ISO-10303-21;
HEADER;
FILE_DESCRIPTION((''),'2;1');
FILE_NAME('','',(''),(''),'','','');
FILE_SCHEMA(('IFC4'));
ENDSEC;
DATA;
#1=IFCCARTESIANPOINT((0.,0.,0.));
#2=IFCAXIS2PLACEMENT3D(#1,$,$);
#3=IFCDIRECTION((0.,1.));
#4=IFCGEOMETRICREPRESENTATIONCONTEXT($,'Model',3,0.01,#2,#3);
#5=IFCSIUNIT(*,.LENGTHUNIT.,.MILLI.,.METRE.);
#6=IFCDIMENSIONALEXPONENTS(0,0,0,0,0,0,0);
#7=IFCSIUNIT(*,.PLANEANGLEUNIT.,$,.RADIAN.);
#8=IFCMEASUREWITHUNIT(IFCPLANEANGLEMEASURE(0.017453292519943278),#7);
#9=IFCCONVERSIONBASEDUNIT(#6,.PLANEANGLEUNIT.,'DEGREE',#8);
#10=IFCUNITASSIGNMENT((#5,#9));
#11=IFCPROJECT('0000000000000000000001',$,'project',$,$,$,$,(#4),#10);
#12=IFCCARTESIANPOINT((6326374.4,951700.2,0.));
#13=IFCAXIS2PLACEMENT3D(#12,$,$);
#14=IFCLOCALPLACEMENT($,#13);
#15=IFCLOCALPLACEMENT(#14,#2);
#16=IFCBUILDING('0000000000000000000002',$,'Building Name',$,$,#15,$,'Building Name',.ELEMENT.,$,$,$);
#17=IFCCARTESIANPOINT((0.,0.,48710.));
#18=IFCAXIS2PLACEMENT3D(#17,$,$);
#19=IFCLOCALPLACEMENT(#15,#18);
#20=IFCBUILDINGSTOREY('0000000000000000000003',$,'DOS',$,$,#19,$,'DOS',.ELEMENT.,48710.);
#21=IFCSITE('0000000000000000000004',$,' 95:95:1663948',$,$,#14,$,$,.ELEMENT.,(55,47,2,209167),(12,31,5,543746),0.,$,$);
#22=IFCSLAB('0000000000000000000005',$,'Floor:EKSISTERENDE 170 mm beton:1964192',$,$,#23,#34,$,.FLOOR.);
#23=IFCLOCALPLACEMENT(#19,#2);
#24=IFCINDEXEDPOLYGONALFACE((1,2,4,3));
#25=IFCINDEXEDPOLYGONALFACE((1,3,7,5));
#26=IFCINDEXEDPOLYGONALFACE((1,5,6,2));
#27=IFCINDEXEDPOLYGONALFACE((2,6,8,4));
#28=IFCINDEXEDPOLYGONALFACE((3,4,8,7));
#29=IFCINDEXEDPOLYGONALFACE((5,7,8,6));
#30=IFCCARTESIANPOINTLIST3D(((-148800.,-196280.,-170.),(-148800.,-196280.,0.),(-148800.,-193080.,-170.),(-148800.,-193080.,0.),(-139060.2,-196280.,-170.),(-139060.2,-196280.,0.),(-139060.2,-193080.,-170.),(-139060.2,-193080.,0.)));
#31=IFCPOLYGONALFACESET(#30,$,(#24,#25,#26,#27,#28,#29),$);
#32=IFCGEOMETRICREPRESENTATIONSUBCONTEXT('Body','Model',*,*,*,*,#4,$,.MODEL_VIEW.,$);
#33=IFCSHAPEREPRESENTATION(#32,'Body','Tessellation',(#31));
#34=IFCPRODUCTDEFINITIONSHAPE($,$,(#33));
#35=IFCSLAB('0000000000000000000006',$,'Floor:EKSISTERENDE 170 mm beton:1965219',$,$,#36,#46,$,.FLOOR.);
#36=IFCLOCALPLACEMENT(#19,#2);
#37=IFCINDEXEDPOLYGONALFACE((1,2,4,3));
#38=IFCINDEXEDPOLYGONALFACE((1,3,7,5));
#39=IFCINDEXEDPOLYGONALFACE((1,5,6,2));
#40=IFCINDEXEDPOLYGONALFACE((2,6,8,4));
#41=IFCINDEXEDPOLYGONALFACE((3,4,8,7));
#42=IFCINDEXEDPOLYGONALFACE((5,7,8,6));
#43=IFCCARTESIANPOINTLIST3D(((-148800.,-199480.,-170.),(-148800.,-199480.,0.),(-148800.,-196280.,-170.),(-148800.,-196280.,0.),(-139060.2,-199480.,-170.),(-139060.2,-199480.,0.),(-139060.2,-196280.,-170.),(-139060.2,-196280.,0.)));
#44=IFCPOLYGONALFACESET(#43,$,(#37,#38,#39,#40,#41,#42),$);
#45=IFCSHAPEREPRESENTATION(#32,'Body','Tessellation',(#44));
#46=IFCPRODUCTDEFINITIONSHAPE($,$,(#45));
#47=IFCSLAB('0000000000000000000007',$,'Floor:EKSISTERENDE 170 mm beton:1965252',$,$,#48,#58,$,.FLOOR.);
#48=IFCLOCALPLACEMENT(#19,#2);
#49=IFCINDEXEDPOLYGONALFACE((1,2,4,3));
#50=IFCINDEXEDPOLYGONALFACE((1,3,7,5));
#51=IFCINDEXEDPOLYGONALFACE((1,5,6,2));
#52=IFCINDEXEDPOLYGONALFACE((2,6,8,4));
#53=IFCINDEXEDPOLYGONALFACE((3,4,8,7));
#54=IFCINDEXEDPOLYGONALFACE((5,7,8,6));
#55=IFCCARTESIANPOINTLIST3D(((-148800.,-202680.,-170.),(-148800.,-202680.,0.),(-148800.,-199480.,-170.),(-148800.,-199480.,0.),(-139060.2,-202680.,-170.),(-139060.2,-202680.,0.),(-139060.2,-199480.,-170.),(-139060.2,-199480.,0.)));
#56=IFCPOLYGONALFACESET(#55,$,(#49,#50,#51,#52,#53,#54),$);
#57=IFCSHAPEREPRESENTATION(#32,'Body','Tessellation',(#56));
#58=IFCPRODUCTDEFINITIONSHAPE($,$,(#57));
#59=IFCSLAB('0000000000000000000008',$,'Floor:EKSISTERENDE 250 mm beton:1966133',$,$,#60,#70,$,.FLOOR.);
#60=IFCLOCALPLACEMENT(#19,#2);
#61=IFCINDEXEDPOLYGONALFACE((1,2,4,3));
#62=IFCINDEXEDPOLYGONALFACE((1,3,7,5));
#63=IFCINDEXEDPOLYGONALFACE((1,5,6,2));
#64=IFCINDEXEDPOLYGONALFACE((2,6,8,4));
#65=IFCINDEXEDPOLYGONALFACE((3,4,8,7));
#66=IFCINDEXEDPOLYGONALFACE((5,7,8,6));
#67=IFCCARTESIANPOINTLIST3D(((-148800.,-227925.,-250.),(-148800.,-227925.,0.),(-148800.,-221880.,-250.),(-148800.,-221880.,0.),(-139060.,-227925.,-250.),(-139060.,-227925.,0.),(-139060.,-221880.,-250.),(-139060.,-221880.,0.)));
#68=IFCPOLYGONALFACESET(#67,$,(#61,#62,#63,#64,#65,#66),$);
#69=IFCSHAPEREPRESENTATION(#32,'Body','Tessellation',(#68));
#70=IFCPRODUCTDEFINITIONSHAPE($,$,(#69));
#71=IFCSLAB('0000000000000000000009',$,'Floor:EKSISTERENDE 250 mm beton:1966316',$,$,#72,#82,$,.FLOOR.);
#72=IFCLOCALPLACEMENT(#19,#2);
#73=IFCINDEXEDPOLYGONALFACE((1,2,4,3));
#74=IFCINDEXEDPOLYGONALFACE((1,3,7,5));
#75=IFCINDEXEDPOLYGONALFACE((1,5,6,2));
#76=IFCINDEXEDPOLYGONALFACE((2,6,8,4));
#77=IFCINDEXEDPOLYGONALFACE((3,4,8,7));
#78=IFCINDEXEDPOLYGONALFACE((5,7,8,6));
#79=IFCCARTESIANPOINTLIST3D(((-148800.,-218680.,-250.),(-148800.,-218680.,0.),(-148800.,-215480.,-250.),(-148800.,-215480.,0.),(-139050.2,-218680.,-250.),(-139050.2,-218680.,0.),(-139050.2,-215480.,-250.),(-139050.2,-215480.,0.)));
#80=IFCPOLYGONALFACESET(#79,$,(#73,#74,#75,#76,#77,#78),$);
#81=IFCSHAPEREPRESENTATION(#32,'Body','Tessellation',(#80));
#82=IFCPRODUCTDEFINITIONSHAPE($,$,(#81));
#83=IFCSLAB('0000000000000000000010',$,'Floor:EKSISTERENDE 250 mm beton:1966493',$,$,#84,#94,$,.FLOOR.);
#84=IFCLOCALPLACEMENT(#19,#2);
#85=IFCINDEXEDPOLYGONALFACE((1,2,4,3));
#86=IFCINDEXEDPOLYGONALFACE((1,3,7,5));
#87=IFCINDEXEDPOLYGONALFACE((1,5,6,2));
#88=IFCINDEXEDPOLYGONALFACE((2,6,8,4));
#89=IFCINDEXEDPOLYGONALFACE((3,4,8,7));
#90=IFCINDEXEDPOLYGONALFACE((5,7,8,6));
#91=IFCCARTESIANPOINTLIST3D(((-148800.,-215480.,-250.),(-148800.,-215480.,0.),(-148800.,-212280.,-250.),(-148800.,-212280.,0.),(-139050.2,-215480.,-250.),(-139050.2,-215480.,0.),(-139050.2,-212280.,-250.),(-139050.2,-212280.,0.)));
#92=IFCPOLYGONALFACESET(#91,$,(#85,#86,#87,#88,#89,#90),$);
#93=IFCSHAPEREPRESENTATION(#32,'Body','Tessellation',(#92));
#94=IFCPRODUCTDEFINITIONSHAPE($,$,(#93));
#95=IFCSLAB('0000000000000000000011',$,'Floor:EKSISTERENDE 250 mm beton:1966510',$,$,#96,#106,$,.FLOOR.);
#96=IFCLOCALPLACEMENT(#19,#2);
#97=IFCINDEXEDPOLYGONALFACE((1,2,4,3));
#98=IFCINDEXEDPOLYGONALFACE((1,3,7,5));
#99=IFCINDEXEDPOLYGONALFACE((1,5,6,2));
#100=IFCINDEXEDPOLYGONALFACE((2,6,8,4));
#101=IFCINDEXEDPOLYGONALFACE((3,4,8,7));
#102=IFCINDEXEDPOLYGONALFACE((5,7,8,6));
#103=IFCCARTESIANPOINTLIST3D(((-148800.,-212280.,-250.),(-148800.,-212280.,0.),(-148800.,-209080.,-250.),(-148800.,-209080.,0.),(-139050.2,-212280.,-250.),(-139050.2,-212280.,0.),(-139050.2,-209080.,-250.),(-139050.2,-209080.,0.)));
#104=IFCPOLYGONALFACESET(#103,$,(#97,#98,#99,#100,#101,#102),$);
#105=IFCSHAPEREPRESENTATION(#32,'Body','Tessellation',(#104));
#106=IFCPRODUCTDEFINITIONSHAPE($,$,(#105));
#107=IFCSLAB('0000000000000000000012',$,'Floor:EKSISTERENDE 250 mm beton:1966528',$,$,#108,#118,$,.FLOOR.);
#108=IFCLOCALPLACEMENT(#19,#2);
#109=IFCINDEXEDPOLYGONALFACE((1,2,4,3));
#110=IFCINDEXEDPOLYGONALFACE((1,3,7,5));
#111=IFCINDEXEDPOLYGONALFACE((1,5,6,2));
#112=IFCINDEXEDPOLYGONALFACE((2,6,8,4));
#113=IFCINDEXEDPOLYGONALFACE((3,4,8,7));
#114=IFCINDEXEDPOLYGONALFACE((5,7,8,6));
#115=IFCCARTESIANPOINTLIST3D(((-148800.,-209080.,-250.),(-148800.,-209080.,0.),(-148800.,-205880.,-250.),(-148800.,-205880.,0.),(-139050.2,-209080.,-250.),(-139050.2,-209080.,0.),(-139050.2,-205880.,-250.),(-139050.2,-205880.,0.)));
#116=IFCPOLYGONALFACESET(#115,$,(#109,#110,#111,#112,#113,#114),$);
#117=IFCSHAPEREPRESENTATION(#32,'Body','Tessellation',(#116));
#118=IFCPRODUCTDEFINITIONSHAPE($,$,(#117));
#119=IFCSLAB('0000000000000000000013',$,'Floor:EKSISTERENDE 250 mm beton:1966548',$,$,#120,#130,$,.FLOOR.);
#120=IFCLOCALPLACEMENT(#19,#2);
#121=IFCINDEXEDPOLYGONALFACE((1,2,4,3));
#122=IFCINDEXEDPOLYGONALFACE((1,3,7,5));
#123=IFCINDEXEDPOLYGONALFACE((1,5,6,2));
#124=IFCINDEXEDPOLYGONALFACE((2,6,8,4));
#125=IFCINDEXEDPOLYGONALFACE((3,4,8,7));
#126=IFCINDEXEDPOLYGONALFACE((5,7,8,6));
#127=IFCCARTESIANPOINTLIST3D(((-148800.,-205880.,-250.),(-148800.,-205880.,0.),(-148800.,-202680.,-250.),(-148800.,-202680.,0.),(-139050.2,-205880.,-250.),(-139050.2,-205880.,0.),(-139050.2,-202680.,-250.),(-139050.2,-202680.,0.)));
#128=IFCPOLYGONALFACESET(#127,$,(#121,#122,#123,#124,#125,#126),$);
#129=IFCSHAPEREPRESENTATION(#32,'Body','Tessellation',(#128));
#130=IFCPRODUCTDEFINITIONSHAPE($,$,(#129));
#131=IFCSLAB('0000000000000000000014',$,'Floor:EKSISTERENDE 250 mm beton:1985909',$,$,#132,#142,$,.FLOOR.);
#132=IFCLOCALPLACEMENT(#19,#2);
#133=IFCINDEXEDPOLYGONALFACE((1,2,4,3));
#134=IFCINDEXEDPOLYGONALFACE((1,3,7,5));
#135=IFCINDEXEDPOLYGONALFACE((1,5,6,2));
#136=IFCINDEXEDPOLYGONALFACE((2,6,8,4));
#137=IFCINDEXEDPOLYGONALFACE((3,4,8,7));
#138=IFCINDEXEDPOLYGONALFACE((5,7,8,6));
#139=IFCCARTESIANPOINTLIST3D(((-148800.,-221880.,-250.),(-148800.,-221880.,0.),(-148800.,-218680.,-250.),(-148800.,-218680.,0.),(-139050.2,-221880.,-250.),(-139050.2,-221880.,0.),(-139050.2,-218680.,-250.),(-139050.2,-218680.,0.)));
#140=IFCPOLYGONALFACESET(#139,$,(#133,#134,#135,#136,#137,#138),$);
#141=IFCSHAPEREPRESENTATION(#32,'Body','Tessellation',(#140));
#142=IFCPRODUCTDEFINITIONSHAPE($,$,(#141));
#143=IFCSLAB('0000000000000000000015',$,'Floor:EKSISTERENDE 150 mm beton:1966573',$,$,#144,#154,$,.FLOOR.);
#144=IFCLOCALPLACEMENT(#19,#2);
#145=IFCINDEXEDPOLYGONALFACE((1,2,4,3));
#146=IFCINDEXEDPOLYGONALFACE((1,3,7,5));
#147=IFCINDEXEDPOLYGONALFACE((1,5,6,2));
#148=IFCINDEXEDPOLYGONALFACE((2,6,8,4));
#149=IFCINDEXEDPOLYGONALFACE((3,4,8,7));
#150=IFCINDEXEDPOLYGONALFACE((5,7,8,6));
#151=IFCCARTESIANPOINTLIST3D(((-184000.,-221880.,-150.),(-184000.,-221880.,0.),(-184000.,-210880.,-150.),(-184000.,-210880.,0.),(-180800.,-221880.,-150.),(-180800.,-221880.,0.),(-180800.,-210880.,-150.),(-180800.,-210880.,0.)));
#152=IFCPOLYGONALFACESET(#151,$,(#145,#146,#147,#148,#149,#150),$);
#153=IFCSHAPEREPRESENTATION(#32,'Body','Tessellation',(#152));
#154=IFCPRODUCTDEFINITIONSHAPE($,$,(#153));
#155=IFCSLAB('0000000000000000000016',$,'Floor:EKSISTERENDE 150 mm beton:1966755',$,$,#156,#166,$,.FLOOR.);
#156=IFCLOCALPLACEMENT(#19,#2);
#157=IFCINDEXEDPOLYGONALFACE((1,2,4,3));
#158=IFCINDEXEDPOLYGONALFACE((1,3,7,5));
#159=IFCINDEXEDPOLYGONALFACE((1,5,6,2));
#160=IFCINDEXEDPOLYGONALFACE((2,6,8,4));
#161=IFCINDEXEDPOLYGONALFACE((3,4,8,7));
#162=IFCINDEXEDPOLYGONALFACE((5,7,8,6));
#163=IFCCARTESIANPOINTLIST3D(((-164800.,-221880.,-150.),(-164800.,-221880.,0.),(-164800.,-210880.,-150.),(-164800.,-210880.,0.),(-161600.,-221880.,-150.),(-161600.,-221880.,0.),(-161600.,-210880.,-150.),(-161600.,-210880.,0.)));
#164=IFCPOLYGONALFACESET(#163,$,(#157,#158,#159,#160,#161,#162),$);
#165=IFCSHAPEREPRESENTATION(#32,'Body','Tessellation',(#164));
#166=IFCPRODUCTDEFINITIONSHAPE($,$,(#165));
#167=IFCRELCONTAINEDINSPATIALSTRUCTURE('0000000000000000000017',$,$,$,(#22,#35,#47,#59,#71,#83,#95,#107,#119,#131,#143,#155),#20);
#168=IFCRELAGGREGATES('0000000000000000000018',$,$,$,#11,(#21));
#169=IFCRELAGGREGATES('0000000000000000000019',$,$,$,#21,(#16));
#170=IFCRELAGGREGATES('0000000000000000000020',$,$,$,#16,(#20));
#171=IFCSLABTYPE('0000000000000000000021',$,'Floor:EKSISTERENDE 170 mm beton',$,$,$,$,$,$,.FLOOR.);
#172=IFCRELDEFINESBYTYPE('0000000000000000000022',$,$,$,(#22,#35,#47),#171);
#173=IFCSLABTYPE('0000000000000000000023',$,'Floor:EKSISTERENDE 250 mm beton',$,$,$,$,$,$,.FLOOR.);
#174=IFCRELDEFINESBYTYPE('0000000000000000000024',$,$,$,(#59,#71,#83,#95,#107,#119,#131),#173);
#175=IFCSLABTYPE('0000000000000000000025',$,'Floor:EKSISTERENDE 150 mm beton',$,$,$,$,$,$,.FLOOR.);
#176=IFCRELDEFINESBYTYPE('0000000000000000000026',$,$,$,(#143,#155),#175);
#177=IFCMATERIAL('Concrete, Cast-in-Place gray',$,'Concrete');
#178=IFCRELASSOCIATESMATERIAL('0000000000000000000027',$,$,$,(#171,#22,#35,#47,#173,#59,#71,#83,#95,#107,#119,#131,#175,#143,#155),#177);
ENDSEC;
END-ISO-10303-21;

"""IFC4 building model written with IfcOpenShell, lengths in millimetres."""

from ifc_helpers import new_model, entity, si_unit, converted_unit, direction, frame, origin, place, context, subcontext, project, spatial, indexed_curve, outline, extrude, material, type_object, element, save


model = new_model("IFC4")

# Units and contexts
model_context = context("Model", 3, precision=0.01, world=origin(), true_north=direction((0.0, 1.0)))
body_context = subcontext(model_context, "Body", "Model", "MODEL_VIEW")
ifc_project = project(units=[si_unit("LENGTHUNIT", "METRE", prefix="MILLI"), converted_unit("PLANEANGLEUNIT", "DEGREE", entity("IfcPlaneAngleMeasure", 0.017453292519943278), si_unit("PLANEANGLEUNIT", "RADIAN"), dimensions=[0, 0, 0, 0, 0, 0, 0])], contexts=[model_context])

# Site, building, storey
site_placement = place(None, frame((6326374.4, 951700.2, 0.0)))
site = spatial("IfcSite", under=ifc_project, at=site_placement, Name=" 95:95:1663948", CompositionType="ELEMENT", RefLatitude=(55, 47, 2, 209167), RefLongitude=(12, 31, 5, 543746), RefElevation=0.0)
building_placement = place(site_placement, origin())
building = spatial("IfcBuilding", under=site, at=building_placement, Name="Building Name", LongName="Building Name", CompositionType="ELEMENT")
storey_placement = place(building_placement, frame((0.0, 0.0, 48710.0)))
storey = spatial("IfcBuildingStorey", under=building, at=storey_placement, Name="DOS", LongName="DOS", CompositionType="ELEMENT", Elevation=48710.0)

# Shared definitions
ifc_material = material(Name="Concrete, Cast-in-Place gray", Category="Concrete")

# Slabs
slab_type_1 = type_object("IfcSlabType", Name="Floor:EKSISTERENDE 170 mm beton", PredefinedType="FLOOR", material=ifc_material)
slab_1_placement = place(storey_placement, origin())
element("IfcSlab", 1, at=slab_1_placement, inside=storey, type_object=slab_type_1, material=ifc_material, Name="Floor:EKSISTERENDE 170 mm beton:1964192", PredefinedType="FLOOR", context=body_context, shape_type="SweptSolid", body=[
    extrude(outline(indexed_curve([(-1600.0, -4869.9), (1600.0, -4869.9), (1600.0, 4869.9), (-1600.0, 4869.9), (-1600.0, -4869.9)], self_intersect=False)), frame((-143930.1, -194680.0, 0.0), z_axis=(0.0, 0.0, -1.0), x_axis=(0.0, 1.0, 0.0)), (0.0, 0.0, 1.0), 170.0),
])
slab_2_placement = place(storey_placement, origin())
element("IfcSlab", 2, at=slab_2_placement, inside=storey, type_object=slab_type_1, material=ifc_material, Name="Floor:EKSISTERENDE 170 mm beton:1965219", PredefinedType="FLOOR", context=body_context, shape_type="SweptSolid", body=[
    extrude(outline(indexed_curve([(-1600.0, -4869.9), (1600.0, -4869.9), (1600.0, 4869.9), (-1600.0, 4869.9), (-1600.0, -4869.9)], self_intersect=False)), frame((-143930.1, -197880.0, 0.0), z_axis=(0.0, 0.0, -1.0), x_axis=(0.0, 1.0, 0.0)), (0.0, 0.0, 1.0), 170.0),
])
slab_3_placement = place(storey_placement, origin())
element("IfcSlab", 3, at=slab_3_placement, inside=storey, type_object=slab_type_1, material=ifc_material, Name="Floor:EKSISTERENDE 170 mm beton:1965252", PredefinedType="FLOOR", context=body_context, shape_type="SweptSolid", body=[
    extrude(outline(indexed_curve([(-1600.0, -4869.9), (1600.0, -4869.9), (1600.0, 4869.9), (-1600.0, 4869.9), (-1600.0, -4869.9)], self_intersect=False)), frame((-143930.1, -201080.0, 0.0), z_axis=(0.0, 0.0, -1.0), x_axis=(0.0, 1.0, 0.0)), (0.0, 0.0, 1.0), 170.0),
])
slab_type_2 = type_object("IfcSlabType", Name="Floor:EKSISTERENDE 250 mm beton", PredefinedType="FLOOR", material=ifc_material)
slab_4_placement = place(storey_placement, origin())
element("IfcSlab", 4, at=slab_4_placement, inside=storey, type_object=slab_type_2, material=ifc_material, Name="Floor:EKSISTERENDE 250 mm beton:1966133", PredefinedType="FLOOR", context=body_context, shape_type="SweptSolid", body=[
    extrude(outline(indexed_curve([(-3022.5, -4870.0), (3022.5, -4870.0), (3022.5, 4870.0), (-3022.5, 4870.0), (-3022.5, -4870.0)], self_intersect=False)), frame((-143930.0, -224902.5, 0.0), z_axis=(0.0, 0.0, -1.0), x_axis=(0.0, 1.0, 0.0)), (0.0, 0.0, 1.0), 250.0),
])
slab_5_placement = place(storey_placement, origin())
element("IfcSlab", 5, at=slab_5_placement, inside=storey, type_object=slab_type_2, material=ifc_material, Name="Floor:EKSISTERENDE 250 mm beton:1966316", PredefinedType="FLOOR", context=body_context, shape_type="SweptSolid", body=[
    extrude(outline(indexed_curve([(-1600.0, -4874.9), (1600.0, -4874.9), (1600.0, 4874.9), (-1600.0, 4874.9), (-1600.0, -4874.9)], self_intersect=False)), frame((-143925.1, -217080.0, 0.0), z_axis=(0.0, 0.0, -1.0), x_axis=(0.0, 1.0, 0.0)), (0.0, 0.0, 1.0), 250.0),
])
slab_6_placement = place(storey_placement, origin())
element("IfcSlab", 6, at=slab_6_placement, inside=storey, type_object=slab_type_2, material=ifc_material, Name="Floor:EKSISTERENDE 250 mm beton:1966493", PredefinedType="FLOOR", context=body_context, shape_type="SweptSolid", body=[
    extrude(outline(indexed_curve([(-1600.0, -4874.9), (1600.0, -4874.9), (1600.0, 4874.9), (-1600.0, 4874.9), (-1600.0, -4874.9)], self_intersect=False)), frame((-143925.1, -213880.0, 0.0), z_axis=(0.0, 0.0, -1.0), x_axis=(0.0, 1.0, 0.0)), (0.0, 0.0, 1.0), 250.0),
])
slab_7_placement = place(storey_placement, origin())
element("IfcSlab", 7, at=slab_7_placement, inside=storey, type_object=slab_type_2, material=ifc_material, Name="Floor:EKSISTERENDE 250 mm beton:1966510", PredefinedType="FLOOR", context=body_context, shape_type="SweptSolid", body=[
    extrude(outline(indexed_curve([(-1600.0, -4874.9), (1600.0, -4874.9), (1600.0, 4874.9), (-1600.0, 4874.9), (-1600.0, -4874.9)], self_intersect=False)), frame((-143925.1, -210680.0, 0.0), z_axis=(0.0, 0.0, -1.0), x_axis=(0.0, 1.0, 0.0)), (0.0, 0.0, 1.0), 250.0),
])
slab_8_placement = place(storey_placement, origin())
element("IfcSlab", 8, at=slab_8_placement, inside=storey, type_object=slab_type_2, material=ifc_material, Name="Floor:EKSISTERENDE 250 mm beton:1966528", PredefinedType="FLOOR", context=body_context, shape_type="SweptSolid", body=[
    extrude(outline(indexed_curve([(-1600.0, -4874.9), (1600.0, -4874.9), (1600.0, 4874.9), (-1600.0, 4874.9), (-1600.0, -4874.9)], self_intersect=False)), frame((-143925.1, -207480.0, 0.0), z_axis=(0.0, 0.0, -1.0), x_axis=(0.0, 1.0, 0.0)), (0.0, 0.0, 1.0), 250.0),
])
slab_9_placement = place(storey_placement, origin())
element("IfcSlab", 9, at=slab_9_placement, inside=storey, type_object=slab_type_2, material=ifc_material, Name="Floor:EKSISTERENDE 250 mm beton:1966548", PredefinedType="FLOOR", context=body_context, shape_type="SweptSolid", body=[
    extrude(outline(indexed_curve([(-1600.0, -4874.9), (1600.0, -4874.9), (1600.0, 4874.9), (-1600.0, 4874.9), (-1600.0, -4874.9)], self_intersect=False)), frame((-143925.1, -204280.0, 0.0), z_axis=(0.0, 0.0, -1.0), x_axis=(0.0, 1.0, 0.0)), (0.0, 0.0, 1.0), 250.0),
])
slab_10_placement = place(storey_placement, origin())
element("IfcSlab", 10, at=slab_10_placement, inside=storey, type_object=slab_type_2, material=ifc_material, Name="Floor:EKSISTERENDE 250 mm beton:1985909", PredefinedType="FLOOR", context=body_context, shape_type="SweptSolid", body=[
    extrude(outline(indexed_curve([(-1600.0, -4874.9), (1600.0, -4874.9), (1600.0, 4874.9), (-1600.0, 4874.9), (-1600.0, -4874.9)], self_intersect=False)), frame((-143925.1, -220280.0, 0.0), z_axis=(0.0, 0.0, -1.0), x_axis=(0.0, 1.0, 0.0)), (0.0, 0.0, 1.0), 250.0),
])
slab_type_3 = type_object("IfcSlabType", Name="Floor:EKSISTERENDE 150 mm beton", PredefinedType="FLOOR", material=ifc_material)
slab_11_placement = place(storey_placement, origin())
element("IfcSlab", 11, at=slab_11_placement, inside=storey, type_object=slab_type_3, material=ifc_material, Name="Floor:EKSISTERENDE 150 mm beton:1966573", PredefinedType="FLOOR", context=body_context, shape_type="SweptSolid", body=[
    extrude(outline(indexed_curve([(-5500.0, -1600.0), (5500.0, -1600.0), (5500.0, 1600.0), (-5500.0, 1600.0), (-5500.0, -1600.0)], self_intersect=False)), frame((-182400.0, -216380.0, 0.0), z_axis=(0.0, 0.0, -1.0), x_axis=(0.0, 1.0, 0.0)), (0.0, 0.0, 1.0), 150.0),
])
slab_12_placement = place(storey_placement, origin())
element("IfcSlab", 12, at=slab_12_placement, inside=storey, type_object=slab_type_3, material=ifc_material, Name="Floor:EKSISTERENDE 150 mm beton:1966755", PredefinedType="FLOOR", context=body_context, shape_type="SweptSolid", body=[
    extrude(outline(indexed_curve([(-5500.0, -1600.0), (5500.0, -1600.0), (5500.0, 1600.0), (-5500.0, 1600.0), (-5500.0, -1600.0)], self_intersect=False)), frame((-163200.0, -216380.0, 0.0), z_axis=(0.0, 0.0, -1.0), x_axis=(0.0, 1.0, 0.0)), (0.0, 0.0, 1.0), 150.0),
])

save(model, "model.ifc")
